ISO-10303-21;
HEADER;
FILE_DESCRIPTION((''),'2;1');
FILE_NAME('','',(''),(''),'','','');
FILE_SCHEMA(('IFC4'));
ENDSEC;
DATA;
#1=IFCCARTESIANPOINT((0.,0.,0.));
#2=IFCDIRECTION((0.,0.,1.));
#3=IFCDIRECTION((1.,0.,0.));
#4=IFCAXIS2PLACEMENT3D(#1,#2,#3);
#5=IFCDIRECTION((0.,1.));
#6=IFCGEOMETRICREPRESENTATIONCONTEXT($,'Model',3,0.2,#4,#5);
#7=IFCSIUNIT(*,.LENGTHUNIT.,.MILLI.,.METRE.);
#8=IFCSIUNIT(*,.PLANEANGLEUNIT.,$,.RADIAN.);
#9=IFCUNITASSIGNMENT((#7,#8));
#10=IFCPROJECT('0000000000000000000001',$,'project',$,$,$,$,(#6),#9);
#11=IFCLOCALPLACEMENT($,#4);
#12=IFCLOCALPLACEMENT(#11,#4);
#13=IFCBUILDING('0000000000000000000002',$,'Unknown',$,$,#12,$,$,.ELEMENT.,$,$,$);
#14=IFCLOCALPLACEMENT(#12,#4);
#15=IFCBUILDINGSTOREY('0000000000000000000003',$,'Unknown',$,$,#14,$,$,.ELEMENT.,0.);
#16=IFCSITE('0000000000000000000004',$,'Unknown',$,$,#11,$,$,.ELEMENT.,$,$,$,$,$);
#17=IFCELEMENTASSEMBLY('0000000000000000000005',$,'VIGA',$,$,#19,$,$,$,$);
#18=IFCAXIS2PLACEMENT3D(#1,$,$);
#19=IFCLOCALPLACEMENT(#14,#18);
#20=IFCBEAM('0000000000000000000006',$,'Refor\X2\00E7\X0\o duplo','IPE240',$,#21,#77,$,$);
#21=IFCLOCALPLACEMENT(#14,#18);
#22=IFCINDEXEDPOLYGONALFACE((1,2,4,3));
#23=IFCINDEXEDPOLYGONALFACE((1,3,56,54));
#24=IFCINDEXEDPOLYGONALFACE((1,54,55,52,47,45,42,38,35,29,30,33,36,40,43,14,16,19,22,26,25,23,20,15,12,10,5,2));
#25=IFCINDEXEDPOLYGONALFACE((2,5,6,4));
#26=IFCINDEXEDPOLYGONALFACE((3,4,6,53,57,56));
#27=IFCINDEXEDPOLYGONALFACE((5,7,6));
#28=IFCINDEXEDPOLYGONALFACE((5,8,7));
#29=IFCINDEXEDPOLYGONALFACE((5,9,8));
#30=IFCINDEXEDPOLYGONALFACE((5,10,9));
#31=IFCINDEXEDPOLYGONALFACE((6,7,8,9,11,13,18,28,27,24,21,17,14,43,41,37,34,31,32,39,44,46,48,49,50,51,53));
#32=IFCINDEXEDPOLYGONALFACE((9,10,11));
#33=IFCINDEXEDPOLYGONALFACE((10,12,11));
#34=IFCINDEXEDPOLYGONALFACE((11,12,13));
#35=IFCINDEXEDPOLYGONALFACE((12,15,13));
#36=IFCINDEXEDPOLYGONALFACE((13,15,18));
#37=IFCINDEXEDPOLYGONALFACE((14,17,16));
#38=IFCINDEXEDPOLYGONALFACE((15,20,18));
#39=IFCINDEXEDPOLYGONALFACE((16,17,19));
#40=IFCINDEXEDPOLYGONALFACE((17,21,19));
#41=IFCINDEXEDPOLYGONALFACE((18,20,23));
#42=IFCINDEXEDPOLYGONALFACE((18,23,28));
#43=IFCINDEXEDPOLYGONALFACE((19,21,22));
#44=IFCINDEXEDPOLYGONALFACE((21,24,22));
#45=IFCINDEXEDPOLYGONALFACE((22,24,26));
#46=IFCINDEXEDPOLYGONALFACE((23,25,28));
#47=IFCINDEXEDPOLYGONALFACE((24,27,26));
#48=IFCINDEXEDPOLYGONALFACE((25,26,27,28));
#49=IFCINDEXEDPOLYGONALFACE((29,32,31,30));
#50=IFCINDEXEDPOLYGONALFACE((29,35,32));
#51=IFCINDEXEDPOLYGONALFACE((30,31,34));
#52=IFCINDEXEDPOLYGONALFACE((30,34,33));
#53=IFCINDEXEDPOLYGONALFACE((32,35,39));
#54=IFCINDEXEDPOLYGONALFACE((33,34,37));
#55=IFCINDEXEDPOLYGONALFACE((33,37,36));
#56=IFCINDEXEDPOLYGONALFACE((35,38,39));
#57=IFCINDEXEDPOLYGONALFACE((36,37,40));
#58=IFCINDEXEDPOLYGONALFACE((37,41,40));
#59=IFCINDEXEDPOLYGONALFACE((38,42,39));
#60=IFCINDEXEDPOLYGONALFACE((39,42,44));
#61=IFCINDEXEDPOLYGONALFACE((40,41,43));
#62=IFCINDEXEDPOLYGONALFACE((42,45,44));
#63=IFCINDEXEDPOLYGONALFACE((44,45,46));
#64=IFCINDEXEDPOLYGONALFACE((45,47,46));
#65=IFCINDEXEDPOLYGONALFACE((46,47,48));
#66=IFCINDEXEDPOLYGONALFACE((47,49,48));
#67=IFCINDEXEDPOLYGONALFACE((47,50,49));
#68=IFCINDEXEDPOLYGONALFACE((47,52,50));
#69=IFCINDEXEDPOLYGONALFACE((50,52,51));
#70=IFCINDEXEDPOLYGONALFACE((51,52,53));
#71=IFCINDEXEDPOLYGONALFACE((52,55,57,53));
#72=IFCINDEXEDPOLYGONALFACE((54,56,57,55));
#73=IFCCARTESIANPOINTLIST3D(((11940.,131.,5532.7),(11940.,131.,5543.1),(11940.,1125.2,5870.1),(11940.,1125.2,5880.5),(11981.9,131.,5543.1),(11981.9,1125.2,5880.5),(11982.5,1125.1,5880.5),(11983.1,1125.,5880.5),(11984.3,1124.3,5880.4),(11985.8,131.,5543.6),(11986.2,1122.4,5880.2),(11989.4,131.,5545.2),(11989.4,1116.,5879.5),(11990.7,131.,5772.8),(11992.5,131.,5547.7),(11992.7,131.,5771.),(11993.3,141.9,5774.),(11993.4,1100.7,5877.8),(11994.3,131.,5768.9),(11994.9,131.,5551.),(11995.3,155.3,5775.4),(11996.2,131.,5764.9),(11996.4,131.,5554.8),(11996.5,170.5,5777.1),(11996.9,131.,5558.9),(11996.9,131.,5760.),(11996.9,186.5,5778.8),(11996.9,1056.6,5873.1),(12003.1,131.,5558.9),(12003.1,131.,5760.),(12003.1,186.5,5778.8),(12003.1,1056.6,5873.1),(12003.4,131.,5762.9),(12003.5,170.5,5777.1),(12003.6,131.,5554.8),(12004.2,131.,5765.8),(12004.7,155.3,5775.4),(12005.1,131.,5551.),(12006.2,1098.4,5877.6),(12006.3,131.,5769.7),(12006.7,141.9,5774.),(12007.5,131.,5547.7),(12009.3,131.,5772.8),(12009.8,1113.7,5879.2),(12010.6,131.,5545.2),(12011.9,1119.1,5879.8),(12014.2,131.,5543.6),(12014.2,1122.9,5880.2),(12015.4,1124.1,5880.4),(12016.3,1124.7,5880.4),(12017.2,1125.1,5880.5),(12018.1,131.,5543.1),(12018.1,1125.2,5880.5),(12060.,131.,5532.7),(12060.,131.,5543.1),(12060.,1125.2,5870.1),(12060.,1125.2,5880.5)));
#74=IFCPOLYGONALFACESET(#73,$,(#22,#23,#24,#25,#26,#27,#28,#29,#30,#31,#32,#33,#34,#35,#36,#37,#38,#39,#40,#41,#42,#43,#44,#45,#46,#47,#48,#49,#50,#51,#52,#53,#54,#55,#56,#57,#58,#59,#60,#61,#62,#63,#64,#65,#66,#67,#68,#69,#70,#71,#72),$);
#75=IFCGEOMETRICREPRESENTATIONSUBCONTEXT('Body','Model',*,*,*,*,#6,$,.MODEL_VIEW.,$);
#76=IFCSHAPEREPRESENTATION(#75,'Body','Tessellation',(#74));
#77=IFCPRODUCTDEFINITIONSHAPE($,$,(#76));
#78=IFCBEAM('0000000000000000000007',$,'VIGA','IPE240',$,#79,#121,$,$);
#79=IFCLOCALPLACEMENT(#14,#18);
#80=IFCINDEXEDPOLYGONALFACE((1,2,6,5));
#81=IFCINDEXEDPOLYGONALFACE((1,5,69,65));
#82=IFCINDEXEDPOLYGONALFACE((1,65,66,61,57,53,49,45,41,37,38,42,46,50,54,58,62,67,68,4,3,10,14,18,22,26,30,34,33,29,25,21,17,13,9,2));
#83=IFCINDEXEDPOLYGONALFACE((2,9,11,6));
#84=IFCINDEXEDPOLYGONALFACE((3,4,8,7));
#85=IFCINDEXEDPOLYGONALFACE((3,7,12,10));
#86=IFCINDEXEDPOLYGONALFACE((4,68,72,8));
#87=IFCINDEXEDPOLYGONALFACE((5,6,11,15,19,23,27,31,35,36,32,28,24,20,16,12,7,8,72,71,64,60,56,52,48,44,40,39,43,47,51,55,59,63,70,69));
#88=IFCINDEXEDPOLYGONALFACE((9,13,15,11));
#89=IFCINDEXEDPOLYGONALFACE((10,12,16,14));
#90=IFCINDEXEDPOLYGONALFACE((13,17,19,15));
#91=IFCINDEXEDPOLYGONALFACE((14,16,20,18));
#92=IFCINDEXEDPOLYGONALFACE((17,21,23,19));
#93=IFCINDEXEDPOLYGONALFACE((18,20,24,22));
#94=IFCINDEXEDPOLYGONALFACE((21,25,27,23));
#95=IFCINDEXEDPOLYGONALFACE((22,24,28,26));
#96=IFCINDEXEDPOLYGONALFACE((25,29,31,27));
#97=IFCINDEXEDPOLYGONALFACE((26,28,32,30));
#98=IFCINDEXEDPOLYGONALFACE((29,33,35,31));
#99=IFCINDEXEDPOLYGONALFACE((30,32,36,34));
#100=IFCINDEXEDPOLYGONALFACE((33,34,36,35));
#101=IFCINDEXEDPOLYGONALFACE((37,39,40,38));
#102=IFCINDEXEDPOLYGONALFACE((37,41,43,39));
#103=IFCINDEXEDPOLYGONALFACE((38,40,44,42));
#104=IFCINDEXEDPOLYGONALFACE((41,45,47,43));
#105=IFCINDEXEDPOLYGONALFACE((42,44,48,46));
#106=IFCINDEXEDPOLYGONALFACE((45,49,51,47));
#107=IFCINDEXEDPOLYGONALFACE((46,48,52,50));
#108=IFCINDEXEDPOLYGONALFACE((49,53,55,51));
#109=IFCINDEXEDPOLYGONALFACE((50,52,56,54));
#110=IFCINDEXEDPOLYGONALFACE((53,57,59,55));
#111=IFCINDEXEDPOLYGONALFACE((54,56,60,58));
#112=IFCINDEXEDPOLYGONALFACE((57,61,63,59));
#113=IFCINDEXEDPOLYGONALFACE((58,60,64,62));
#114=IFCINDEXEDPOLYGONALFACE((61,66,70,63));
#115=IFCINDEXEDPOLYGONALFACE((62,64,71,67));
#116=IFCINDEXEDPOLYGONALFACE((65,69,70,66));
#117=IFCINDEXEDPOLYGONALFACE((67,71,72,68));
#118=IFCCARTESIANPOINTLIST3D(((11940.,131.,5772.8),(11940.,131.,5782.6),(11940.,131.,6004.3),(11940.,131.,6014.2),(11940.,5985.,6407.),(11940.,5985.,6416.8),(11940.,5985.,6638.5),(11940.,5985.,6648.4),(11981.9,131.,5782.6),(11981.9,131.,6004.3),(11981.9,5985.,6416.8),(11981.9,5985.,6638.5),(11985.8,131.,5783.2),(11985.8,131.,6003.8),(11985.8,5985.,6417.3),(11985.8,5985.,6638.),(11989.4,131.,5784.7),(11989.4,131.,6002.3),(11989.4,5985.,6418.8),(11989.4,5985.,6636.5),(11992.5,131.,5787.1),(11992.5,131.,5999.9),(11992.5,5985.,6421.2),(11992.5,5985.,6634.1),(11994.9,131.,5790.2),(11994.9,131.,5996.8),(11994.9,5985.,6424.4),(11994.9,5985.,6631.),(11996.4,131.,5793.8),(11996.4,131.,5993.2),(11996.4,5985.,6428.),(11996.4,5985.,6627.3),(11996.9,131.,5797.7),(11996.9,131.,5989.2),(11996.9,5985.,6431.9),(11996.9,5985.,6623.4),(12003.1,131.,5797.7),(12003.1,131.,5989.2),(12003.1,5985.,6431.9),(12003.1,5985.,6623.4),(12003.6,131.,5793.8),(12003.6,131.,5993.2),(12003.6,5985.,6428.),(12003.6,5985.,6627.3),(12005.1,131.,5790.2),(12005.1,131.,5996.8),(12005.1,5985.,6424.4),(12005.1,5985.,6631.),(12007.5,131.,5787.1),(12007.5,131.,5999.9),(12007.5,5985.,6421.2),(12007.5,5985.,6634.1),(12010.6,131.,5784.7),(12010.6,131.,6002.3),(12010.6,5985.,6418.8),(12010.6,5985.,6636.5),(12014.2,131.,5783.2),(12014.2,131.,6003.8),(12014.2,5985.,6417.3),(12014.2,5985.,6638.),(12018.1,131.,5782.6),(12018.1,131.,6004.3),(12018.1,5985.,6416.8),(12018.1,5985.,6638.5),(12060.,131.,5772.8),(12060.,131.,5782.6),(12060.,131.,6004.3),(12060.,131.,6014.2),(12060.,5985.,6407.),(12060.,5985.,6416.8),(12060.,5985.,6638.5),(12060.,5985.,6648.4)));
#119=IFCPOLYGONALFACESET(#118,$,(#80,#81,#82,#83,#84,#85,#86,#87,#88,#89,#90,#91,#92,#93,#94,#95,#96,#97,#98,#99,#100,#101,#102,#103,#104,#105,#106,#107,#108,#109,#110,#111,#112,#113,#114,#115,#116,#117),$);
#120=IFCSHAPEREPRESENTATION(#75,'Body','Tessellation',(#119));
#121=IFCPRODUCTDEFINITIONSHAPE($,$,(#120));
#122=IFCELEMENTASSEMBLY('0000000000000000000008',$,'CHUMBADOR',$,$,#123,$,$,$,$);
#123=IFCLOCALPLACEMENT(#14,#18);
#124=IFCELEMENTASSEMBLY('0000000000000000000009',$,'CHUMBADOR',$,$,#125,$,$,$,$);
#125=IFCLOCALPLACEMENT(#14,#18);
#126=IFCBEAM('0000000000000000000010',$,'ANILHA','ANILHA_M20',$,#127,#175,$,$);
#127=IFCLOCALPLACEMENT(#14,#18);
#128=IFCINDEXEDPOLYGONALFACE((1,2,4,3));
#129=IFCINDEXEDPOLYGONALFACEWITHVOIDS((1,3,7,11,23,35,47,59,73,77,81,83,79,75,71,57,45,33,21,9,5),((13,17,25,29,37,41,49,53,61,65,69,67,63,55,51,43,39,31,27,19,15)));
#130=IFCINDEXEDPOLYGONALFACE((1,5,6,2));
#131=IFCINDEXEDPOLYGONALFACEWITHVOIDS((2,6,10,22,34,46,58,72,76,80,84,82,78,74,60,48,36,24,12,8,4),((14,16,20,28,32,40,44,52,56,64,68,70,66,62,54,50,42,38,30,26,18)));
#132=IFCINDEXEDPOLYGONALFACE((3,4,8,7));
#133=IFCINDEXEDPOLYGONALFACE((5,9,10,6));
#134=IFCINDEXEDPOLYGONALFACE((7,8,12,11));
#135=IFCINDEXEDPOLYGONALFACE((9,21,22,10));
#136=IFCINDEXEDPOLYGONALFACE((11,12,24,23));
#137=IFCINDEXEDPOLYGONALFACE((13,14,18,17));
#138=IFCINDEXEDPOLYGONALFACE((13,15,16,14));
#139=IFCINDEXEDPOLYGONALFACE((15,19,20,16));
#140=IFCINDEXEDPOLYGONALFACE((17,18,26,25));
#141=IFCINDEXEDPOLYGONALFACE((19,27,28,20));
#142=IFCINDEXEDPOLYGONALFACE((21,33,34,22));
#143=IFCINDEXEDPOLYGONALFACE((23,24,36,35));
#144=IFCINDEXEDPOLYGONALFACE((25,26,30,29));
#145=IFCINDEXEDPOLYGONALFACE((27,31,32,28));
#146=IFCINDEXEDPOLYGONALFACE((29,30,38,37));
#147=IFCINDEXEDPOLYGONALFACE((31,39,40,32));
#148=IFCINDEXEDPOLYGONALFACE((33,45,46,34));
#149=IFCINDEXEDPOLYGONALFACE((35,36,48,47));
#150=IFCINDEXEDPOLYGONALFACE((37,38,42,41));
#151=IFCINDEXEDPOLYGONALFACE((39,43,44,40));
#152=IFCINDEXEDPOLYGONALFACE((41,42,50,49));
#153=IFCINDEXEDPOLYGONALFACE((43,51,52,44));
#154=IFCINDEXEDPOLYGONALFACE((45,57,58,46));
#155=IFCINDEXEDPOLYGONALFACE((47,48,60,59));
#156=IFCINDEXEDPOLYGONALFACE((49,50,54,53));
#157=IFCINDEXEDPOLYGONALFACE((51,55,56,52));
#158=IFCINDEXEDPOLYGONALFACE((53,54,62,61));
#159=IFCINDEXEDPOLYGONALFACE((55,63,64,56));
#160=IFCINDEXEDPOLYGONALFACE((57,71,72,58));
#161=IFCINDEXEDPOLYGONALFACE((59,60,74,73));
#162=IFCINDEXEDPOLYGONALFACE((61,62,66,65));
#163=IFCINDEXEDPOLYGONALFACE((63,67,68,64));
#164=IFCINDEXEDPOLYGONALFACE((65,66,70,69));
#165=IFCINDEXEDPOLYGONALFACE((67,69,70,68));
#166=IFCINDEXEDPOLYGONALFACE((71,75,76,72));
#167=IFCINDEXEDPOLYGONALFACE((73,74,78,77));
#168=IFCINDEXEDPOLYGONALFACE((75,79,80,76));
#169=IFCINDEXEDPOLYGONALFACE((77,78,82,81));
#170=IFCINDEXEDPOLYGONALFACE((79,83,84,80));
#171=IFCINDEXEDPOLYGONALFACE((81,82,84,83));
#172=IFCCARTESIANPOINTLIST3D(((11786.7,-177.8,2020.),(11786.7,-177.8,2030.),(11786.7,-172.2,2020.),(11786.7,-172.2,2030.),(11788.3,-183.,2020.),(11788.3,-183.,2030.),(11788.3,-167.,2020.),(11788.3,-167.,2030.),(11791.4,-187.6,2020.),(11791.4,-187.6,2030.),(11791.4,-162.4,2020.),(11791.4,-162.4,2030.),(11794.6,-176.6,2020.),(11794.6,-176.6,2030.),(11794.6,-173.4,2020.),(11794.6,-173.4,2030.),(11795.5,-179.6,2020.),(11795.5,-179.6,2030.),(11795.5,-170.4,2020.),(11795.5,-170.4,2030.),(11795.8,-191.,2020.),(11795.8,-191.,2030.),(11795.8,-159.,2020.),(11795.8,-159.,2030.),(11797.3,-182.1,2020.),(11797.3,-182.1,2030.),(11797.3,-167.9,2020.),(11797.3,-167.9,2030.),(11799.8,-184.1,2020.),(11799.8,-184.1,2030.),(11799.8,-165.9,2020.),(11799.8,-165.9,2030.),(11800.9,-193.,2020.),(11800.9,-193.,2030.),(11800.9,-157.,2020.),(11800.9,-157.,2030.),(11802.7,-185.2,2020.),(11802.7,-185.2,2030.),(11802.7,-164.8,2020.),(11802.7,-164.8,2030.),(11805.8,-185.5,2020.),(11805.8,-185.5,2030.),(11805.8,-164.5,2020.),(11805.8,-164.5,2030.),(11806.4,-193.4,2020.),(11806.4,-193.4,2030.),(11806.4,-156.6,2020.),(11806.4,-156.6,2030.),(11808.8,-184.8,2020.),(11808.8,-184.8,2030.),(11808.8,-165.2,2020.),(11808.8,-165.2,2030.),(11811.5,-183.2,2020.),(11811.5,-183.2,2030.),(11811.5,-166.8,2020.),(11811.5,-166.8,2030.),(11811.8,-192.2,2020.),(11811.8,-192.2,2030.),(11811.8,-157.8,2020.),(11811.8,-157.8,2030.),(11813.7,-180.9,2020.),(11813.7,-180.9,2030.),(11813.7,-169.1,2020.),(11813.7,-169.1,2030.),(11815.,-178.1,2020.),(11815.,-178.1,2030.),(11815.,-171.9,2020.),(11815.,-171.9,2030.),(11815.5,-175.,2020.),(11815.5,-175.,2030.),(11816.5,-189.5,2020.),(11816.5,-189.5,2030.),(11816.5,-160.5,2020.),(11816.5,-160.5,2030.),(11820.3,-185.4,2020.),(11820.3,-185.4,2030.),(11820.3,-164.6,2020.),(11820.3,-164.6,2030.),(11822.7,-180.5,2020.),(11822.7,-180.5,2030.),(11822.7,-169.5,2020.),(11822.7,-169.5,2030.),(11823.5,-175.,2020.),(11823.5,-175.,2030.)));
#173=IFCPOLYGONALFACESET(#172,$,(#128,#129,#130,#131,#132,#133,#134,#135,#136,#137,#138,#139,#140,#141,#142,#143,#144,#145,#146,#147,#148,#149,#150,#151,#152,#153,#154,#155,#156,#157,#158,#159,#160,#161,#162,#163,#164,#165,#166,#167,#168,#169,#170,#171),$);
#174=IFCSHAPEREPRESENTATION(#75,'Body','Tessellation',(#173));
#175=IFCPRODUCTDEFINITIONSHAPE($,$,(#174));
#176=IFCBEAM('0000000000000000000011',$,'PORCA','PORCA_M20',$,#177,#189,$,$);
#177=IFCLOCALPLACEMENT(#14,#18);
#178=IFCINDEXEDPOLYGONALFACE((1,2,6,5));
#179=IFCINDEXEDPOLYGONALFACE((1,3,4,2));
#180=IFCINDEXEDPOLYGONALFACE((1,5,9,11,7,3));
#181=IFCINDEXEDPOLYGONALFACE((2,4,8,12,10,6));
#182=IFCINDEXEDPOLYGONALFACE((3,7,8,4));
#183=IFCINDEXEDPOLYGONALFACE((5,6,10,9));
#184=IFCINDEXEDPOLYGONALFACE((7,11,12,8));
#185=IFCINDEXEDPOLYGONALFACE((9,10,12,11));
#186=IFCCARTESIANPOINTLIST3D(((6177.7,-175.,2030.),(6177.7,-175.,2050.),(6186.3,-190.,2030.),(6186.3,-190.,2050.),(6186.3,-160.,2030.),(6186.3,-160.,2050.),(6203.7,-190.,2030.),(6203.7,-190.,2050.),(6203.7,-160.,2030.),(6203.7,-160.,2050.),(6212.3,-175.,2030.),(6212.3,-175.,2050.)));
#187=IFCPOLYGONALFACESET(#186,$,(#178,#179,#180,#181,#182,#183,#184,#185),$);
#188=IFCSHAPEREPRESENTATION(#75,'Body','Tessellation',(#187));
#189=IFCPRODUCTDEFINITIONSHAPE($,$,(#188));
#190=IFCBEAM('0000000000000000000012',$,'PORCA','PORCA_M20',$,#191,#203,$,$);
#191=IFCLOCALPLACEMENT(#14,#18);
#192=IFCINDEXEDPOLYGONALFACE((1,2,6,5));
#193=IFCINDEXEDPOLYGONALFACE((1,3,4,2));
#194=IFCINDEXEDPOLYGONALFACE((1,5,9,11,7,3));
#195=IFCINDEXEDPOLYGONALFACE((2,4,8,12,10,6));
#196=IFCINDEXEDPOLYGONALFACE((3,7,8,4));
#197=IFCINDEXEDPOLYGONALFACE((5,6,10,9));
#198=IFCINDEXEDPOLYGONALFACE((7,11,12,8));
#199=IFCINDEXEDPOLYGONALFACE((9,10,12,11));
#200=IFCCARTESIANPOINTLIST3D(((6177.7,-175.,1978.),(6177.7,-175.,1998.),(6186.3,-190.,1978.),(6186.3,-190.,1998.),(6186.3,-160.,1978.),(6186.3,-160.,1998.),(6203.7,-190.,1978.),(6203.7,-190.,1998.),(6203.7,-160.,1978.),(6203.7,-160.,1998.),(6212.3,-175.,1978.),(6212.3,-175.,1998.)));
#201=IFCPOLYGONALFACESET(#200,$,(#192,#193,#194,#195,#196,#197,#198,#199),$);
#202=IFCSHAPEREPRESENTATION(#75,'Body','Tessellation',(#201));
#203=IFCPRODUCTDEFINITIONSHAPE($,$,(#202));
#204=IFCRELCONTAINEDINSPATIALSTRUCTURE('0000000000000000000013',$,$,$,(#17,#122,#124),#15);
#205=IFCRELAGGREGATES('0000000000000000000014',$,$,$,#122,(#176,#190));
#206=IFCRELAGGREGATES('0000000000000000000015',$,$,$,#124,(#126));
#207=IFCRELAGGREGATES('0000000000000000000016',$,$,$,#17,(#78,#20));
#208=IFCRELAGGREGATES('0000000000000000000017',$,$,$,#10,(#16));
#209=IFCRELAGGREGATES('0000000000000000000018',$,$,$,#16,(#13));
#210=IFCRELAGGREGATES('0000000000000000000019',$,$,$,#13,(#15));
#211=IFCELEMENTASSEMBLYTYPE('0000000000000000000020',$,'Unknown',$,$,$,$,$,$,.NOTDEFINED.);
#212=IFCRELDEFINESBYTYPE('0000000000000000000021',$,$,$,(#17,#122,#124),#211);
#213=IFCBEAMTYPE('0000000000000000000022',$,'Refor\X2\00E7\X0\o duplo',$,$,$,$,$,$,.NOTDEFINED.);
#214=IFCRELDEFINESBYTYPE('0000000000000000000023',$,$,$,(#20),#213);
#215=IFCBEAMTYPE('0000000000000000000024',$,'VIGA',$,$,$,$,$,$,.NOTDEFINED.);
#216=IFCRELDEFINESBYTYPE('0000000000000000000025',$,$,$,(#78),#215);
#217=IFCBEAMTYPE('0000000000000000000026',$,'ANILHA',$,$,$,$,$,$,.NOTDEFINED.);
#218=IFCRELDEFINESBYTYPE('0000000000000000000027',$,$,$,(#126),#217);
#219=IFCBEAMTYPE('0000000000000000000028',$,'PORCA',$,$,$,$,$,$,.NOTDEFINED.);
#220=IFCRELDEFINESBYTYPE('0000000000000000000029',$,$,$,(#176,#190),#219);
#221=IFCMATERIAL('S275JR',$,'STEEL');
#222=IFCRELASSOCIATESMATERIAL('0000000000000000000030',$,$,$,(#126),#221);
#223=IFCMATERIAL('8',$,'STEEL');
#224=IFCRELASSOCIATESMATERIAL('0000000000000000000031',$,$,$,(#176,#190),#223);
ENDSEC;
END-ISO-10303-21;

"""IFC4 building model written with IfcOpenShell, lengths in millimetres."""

from ifc_helpers import new_model, si_unit, direction, frame, origin_with_axes, origin_2d_with_axis, place, context, subcontext, project, spatial, polyline, hollow_circle, i_section, outline, extrude, clip, halfspace, material, material_profile, profile_set, profile_usage, type_object, element, aggregate, save


model = new_model("IFC4")

# Units and contexts
model_context = context("Model", 3, precision=0.2, world=origin_with_axes(), true_north=direction((0.0, 1.0)))
body_context = subcontext(model_context, "Body", "Model", "MODEL_VIEW")
ifc_project = project(units=[si_unit("LENGTHUNIT", "METRE", prefix="MILLI"), si_unit("PLANEANGLEUNIT", "RADIAN")], contexts=[model_context])

# Site, building, storey
site_placement = place(None, origin_with_axes())
site = spatial("IfcSite", under=ifc_project, at=site_placement, Name="Unknown", CompositionType="ELEMENT")
building_placement = place(site_placement, origin_with_axes())
building = spatial("IfcBuilding", under=site, at=building_placement, Name="Unknown", CompositionType="ELEMENT")
storey_placement = place(building_placement, origin_with_axes())
storey = spatial("IfcBuildingStorey", under=building, at=storey_placement, Name="Unknown", CompositionType="ELEMENT", Elevation=0.0)

# Shared definitions
element_assembly_type = type_object("IfcElementAssemblyType", Name="Unknown", PredefinedType="NOTDEFINED")

# Element assembly
assembly_1_placement = place(storey_placement, frame((12000.0, 12.9, 5880.7), z_axis=(1.0, 0.0, 0.0), x_axis=(0.0, 0.994183, 0.107703)))
assembly_1 = element("IfcElementAssembly", 1, at=assembly_1_placement, inside=storey, type_object=element_assembly_type, Name="VIGA")

# Beams
beam_type_1 = type_object("IfcBeamType", Name="Reforço duplo", PredefinedType="NOTDEFINED")
beam_1_placement = place(assembly_1_placement, frame((53.8, -241.6, 0.0), z_axis=(0.0, 0.0, 1.0), x_axis=(0.976051, 0.217543, 0.0)))
beam_1 = element("IfcBeam", 2, at=beam_1_placement, type_object=beam_type_1, Name="Reforço duplo", Description="IPE240", context=body_context, shape_type="Clipping", body=[
    clip(clip(clip(extrude(i_section(OverallWidth=120.0, OverallDepth=240.0, WebThickness=6.2, FlangeThickness=9.8, FilletRadius=15.0, FlangeEdgeRadius=0.0, FlangeSlope=0.0, at=origin_2d_with_axis()), frame((-199.3, 0.0, 0.0), z_axis=(-1.0, 0.0, 0.0), x_axis=(0.0, 0.0, 1.0)), (0.0, 0.0, -1.0), 1529.9), halfspace(frame((476.2, 1282.9, 0.0), z_axis=(-0.946943, 0.321401, 0.0), x_axis=(-0.321401, -0.946943, 0.0)), False)), halfspace(frame((20.4, 120.0, -60.0), z_axis=(0.217543, 0.976051, 0.0), x_axis=(0.0, 0.0, 1.0)), False)), halfspace(frame((1049.9, -120.0, 0.0), z_axis=(0.946943, -0.321401, 0.0), x_axis=(0.321401, 0.946943, 0.0)), False)),
])
beam_type_2 = type_object("IfcBeamType", Name="VIGA", PredefinedType="NOTDEFINED")
beam_2_placement = place(assembly_1_placement, origin_with_axes())
beam_2 = element("IfcBeam", 3, at=beam_2_placement, type_object=beam_type_2, Name="VIGA", Description="IPE240", context=body_context, shape_type="Clipping", body=[
    clip(clip(extrude(i_section(OverallWidth=120.0, OverallDepth=240.0, WebThickness=6.2, FlangeThickness=9.8, FilletRadius=15.0, FlangeEdgeRadius=0.0, FlangeSlope=0.0, at=origin_2d_with_axis()), frame((-121.2, 0.0, 0.0), z_axis=(-1.0, 0.0, 0.0), x_axis=(0.0, 0.0, 1.0)), (0.0, 0.0, -1.0), 6368.3), halfspace(frame((6021.8, 136.5, 0.0), z_axis=(0.994183, -0.107703, 0.0), x_axis=(-0.107703, -0.994183, 0.0)), False)), halfspace(frame((105.8, -120.0, 0.0), z_axis=(0.994183, -0.107703, 0.0), x_axis=(0.107703, 0.994183, 0.0)), True)),
])

# Element assemblies, beam
assembly_2_placement = place(storey_placement, frame((5805.0, -175.0, 1945.0), z_axis=(1.0, 0.0, 0.0), x_axis=(0.0, 0.0, -1.0)))
assembly_2 = element("IfcElementAssembly", 4, at=assembly_2_placement, inside=storey, type_object=element_assembly_type, Name="CHUMBADOR")
ifc_material_1 = material(Name="S275JR", Category="STEEL")
ifc_material_profile_1 = material_profile(ifc_material_1, hollow_circle(Radius=18.5, WallThickness=8.0, at=origin_2d_with_axis()), Name="ANILHA_M20")
ifc_profile_set_1 = profile_set([ifc_material_profile_1])
ifc_profile_usage_1 = profile_usage(ifc_profile_set_1, cardinal=5)
beam_type_3 = type_object("IfcBeamType", Name="ANILHA", PredefinedType="NOTDEFINED")
assembly_3_placement = place(storey_placement, frame((11805.0, -175.0, 1945.0), z_axis=(1.0, 0.0, 0.0), x_axis=(0.0, 0.0, -1.0)))
assembly_3 = element("IfcElementAssembly", 5, at=assembly_3_placement, inside=storey, type_object=element_assembly_type, Name="CHUMBADOR")
beam_3_placement = place(assembly_3_placement, frame((-85.0, 0.0, 0.0), z_axis=(0.0, 0.0, 1.0), x_axis=(1.0, 0.0, 0.0)))
beam_3 = element("IfcBeam", 6, at=beam_3_placement, type_object=beam_type_3, material=ifc_profile_usage_1, Name="ANILHA", Description="ANILHA_M20", context=body_context, shape_type="SolidModel", body=[
    extrude(hollow_circle(Radius=18.5, WallThickness=8.0, at=origin_2d_with_axis()), frame((0.0, 0.0, 0.0), z_axis=(-1.0, 0.0, 0.0), x_axis=(0.0, 0.0, 1.0)), (0.0, 0.0, -1.0), 10.0),
])

# Beams
ifc_material_2 = material(Name="8", Category="STEEL")
ifc_material_profile_2 = material_profile(ifc_material_2, outline(polyline([(8.7, -15.0), (17.3, 0.0), (8.7, 15.0), (-8.7, 15.0), (-17.3, 0.0), (-8.7, -15.0), (8.7, -15.0)])), Name="PORCA_M20")
ifc_profile_set_2 = profile_set([ifc_material_profile_2])
ifc_profile_usage_2 = profile_usage(ifc_profile_set_2, cardinal=5)
beam_type_4 = type_object("IfcBeamType", Name="PORCA", PredefinedType="NOTDEFINED")
beam_4_placement = place(assembly_2_placement, frame((-105.0, 0.0, 390.0), z_axis=(0.0, 0.0, 1.0), x_axis=(1.0, 0.0, 0.0)))
beam_4 = element("IfcBeam", 7, at=beam_4_placement, type_object=beam_type_4, material=ifc_profile_usage_2, Name="PORCA", Description="PORCA_M20", context=body_context, shape_type="SolidModel", body=[
    extrude(outline(polyline([(8.7, -15.0), (17.3, 0.0), (8.7, 15.0), (-8.7, 15.0), (-17.3, 0.0), (-8.7, -15.0), (8.7, -15.0)])), frame((0.0, 0.0, 0.0), z_axis=(-1.0, 0.0, 0.0), x_axis=(0.0, 0.0, 1.0)), (0.0, 0.0, -1.0), 20.0),
])
beam_5_placement = place(assembly_2_placement, frame((-53.0, 0.0, 390.0), z_axis=(0.0, 0.0, 1.0), x_axis=(1.0, 0.0, 0.0)))
beam_5 = element("IfcBeam", 8, at=beam_5_placement, type_object=beam_type_4, material=ifc_profile_usage_2, Name="PORCA", Description="PORCA_M20", context=body_context, shape_type="SolidModel", body=[
    extrude(outline(polyline([(8.7, -15.0), (17.3, 0.0), (8.7, 15.0), (-8.7, 15.0), (-17.3, 0.0), (-8.7, -15.0), (8.7, -15.0)])), frame((0.0, 0.0, 0.0), z_axis=(-1.0, 0.0, 0.0), x_axis=(0.0, 0.0, 1.0)), (0.0, 0.0, -1.0), 20.0),
])
aggregate(assembly_2, [beam_4, beam_5])
aggregate(assembly_3, [beam_3])

aggregate(assembly_1, [beam_2, beam_1])

save(model, "model.ifc")
